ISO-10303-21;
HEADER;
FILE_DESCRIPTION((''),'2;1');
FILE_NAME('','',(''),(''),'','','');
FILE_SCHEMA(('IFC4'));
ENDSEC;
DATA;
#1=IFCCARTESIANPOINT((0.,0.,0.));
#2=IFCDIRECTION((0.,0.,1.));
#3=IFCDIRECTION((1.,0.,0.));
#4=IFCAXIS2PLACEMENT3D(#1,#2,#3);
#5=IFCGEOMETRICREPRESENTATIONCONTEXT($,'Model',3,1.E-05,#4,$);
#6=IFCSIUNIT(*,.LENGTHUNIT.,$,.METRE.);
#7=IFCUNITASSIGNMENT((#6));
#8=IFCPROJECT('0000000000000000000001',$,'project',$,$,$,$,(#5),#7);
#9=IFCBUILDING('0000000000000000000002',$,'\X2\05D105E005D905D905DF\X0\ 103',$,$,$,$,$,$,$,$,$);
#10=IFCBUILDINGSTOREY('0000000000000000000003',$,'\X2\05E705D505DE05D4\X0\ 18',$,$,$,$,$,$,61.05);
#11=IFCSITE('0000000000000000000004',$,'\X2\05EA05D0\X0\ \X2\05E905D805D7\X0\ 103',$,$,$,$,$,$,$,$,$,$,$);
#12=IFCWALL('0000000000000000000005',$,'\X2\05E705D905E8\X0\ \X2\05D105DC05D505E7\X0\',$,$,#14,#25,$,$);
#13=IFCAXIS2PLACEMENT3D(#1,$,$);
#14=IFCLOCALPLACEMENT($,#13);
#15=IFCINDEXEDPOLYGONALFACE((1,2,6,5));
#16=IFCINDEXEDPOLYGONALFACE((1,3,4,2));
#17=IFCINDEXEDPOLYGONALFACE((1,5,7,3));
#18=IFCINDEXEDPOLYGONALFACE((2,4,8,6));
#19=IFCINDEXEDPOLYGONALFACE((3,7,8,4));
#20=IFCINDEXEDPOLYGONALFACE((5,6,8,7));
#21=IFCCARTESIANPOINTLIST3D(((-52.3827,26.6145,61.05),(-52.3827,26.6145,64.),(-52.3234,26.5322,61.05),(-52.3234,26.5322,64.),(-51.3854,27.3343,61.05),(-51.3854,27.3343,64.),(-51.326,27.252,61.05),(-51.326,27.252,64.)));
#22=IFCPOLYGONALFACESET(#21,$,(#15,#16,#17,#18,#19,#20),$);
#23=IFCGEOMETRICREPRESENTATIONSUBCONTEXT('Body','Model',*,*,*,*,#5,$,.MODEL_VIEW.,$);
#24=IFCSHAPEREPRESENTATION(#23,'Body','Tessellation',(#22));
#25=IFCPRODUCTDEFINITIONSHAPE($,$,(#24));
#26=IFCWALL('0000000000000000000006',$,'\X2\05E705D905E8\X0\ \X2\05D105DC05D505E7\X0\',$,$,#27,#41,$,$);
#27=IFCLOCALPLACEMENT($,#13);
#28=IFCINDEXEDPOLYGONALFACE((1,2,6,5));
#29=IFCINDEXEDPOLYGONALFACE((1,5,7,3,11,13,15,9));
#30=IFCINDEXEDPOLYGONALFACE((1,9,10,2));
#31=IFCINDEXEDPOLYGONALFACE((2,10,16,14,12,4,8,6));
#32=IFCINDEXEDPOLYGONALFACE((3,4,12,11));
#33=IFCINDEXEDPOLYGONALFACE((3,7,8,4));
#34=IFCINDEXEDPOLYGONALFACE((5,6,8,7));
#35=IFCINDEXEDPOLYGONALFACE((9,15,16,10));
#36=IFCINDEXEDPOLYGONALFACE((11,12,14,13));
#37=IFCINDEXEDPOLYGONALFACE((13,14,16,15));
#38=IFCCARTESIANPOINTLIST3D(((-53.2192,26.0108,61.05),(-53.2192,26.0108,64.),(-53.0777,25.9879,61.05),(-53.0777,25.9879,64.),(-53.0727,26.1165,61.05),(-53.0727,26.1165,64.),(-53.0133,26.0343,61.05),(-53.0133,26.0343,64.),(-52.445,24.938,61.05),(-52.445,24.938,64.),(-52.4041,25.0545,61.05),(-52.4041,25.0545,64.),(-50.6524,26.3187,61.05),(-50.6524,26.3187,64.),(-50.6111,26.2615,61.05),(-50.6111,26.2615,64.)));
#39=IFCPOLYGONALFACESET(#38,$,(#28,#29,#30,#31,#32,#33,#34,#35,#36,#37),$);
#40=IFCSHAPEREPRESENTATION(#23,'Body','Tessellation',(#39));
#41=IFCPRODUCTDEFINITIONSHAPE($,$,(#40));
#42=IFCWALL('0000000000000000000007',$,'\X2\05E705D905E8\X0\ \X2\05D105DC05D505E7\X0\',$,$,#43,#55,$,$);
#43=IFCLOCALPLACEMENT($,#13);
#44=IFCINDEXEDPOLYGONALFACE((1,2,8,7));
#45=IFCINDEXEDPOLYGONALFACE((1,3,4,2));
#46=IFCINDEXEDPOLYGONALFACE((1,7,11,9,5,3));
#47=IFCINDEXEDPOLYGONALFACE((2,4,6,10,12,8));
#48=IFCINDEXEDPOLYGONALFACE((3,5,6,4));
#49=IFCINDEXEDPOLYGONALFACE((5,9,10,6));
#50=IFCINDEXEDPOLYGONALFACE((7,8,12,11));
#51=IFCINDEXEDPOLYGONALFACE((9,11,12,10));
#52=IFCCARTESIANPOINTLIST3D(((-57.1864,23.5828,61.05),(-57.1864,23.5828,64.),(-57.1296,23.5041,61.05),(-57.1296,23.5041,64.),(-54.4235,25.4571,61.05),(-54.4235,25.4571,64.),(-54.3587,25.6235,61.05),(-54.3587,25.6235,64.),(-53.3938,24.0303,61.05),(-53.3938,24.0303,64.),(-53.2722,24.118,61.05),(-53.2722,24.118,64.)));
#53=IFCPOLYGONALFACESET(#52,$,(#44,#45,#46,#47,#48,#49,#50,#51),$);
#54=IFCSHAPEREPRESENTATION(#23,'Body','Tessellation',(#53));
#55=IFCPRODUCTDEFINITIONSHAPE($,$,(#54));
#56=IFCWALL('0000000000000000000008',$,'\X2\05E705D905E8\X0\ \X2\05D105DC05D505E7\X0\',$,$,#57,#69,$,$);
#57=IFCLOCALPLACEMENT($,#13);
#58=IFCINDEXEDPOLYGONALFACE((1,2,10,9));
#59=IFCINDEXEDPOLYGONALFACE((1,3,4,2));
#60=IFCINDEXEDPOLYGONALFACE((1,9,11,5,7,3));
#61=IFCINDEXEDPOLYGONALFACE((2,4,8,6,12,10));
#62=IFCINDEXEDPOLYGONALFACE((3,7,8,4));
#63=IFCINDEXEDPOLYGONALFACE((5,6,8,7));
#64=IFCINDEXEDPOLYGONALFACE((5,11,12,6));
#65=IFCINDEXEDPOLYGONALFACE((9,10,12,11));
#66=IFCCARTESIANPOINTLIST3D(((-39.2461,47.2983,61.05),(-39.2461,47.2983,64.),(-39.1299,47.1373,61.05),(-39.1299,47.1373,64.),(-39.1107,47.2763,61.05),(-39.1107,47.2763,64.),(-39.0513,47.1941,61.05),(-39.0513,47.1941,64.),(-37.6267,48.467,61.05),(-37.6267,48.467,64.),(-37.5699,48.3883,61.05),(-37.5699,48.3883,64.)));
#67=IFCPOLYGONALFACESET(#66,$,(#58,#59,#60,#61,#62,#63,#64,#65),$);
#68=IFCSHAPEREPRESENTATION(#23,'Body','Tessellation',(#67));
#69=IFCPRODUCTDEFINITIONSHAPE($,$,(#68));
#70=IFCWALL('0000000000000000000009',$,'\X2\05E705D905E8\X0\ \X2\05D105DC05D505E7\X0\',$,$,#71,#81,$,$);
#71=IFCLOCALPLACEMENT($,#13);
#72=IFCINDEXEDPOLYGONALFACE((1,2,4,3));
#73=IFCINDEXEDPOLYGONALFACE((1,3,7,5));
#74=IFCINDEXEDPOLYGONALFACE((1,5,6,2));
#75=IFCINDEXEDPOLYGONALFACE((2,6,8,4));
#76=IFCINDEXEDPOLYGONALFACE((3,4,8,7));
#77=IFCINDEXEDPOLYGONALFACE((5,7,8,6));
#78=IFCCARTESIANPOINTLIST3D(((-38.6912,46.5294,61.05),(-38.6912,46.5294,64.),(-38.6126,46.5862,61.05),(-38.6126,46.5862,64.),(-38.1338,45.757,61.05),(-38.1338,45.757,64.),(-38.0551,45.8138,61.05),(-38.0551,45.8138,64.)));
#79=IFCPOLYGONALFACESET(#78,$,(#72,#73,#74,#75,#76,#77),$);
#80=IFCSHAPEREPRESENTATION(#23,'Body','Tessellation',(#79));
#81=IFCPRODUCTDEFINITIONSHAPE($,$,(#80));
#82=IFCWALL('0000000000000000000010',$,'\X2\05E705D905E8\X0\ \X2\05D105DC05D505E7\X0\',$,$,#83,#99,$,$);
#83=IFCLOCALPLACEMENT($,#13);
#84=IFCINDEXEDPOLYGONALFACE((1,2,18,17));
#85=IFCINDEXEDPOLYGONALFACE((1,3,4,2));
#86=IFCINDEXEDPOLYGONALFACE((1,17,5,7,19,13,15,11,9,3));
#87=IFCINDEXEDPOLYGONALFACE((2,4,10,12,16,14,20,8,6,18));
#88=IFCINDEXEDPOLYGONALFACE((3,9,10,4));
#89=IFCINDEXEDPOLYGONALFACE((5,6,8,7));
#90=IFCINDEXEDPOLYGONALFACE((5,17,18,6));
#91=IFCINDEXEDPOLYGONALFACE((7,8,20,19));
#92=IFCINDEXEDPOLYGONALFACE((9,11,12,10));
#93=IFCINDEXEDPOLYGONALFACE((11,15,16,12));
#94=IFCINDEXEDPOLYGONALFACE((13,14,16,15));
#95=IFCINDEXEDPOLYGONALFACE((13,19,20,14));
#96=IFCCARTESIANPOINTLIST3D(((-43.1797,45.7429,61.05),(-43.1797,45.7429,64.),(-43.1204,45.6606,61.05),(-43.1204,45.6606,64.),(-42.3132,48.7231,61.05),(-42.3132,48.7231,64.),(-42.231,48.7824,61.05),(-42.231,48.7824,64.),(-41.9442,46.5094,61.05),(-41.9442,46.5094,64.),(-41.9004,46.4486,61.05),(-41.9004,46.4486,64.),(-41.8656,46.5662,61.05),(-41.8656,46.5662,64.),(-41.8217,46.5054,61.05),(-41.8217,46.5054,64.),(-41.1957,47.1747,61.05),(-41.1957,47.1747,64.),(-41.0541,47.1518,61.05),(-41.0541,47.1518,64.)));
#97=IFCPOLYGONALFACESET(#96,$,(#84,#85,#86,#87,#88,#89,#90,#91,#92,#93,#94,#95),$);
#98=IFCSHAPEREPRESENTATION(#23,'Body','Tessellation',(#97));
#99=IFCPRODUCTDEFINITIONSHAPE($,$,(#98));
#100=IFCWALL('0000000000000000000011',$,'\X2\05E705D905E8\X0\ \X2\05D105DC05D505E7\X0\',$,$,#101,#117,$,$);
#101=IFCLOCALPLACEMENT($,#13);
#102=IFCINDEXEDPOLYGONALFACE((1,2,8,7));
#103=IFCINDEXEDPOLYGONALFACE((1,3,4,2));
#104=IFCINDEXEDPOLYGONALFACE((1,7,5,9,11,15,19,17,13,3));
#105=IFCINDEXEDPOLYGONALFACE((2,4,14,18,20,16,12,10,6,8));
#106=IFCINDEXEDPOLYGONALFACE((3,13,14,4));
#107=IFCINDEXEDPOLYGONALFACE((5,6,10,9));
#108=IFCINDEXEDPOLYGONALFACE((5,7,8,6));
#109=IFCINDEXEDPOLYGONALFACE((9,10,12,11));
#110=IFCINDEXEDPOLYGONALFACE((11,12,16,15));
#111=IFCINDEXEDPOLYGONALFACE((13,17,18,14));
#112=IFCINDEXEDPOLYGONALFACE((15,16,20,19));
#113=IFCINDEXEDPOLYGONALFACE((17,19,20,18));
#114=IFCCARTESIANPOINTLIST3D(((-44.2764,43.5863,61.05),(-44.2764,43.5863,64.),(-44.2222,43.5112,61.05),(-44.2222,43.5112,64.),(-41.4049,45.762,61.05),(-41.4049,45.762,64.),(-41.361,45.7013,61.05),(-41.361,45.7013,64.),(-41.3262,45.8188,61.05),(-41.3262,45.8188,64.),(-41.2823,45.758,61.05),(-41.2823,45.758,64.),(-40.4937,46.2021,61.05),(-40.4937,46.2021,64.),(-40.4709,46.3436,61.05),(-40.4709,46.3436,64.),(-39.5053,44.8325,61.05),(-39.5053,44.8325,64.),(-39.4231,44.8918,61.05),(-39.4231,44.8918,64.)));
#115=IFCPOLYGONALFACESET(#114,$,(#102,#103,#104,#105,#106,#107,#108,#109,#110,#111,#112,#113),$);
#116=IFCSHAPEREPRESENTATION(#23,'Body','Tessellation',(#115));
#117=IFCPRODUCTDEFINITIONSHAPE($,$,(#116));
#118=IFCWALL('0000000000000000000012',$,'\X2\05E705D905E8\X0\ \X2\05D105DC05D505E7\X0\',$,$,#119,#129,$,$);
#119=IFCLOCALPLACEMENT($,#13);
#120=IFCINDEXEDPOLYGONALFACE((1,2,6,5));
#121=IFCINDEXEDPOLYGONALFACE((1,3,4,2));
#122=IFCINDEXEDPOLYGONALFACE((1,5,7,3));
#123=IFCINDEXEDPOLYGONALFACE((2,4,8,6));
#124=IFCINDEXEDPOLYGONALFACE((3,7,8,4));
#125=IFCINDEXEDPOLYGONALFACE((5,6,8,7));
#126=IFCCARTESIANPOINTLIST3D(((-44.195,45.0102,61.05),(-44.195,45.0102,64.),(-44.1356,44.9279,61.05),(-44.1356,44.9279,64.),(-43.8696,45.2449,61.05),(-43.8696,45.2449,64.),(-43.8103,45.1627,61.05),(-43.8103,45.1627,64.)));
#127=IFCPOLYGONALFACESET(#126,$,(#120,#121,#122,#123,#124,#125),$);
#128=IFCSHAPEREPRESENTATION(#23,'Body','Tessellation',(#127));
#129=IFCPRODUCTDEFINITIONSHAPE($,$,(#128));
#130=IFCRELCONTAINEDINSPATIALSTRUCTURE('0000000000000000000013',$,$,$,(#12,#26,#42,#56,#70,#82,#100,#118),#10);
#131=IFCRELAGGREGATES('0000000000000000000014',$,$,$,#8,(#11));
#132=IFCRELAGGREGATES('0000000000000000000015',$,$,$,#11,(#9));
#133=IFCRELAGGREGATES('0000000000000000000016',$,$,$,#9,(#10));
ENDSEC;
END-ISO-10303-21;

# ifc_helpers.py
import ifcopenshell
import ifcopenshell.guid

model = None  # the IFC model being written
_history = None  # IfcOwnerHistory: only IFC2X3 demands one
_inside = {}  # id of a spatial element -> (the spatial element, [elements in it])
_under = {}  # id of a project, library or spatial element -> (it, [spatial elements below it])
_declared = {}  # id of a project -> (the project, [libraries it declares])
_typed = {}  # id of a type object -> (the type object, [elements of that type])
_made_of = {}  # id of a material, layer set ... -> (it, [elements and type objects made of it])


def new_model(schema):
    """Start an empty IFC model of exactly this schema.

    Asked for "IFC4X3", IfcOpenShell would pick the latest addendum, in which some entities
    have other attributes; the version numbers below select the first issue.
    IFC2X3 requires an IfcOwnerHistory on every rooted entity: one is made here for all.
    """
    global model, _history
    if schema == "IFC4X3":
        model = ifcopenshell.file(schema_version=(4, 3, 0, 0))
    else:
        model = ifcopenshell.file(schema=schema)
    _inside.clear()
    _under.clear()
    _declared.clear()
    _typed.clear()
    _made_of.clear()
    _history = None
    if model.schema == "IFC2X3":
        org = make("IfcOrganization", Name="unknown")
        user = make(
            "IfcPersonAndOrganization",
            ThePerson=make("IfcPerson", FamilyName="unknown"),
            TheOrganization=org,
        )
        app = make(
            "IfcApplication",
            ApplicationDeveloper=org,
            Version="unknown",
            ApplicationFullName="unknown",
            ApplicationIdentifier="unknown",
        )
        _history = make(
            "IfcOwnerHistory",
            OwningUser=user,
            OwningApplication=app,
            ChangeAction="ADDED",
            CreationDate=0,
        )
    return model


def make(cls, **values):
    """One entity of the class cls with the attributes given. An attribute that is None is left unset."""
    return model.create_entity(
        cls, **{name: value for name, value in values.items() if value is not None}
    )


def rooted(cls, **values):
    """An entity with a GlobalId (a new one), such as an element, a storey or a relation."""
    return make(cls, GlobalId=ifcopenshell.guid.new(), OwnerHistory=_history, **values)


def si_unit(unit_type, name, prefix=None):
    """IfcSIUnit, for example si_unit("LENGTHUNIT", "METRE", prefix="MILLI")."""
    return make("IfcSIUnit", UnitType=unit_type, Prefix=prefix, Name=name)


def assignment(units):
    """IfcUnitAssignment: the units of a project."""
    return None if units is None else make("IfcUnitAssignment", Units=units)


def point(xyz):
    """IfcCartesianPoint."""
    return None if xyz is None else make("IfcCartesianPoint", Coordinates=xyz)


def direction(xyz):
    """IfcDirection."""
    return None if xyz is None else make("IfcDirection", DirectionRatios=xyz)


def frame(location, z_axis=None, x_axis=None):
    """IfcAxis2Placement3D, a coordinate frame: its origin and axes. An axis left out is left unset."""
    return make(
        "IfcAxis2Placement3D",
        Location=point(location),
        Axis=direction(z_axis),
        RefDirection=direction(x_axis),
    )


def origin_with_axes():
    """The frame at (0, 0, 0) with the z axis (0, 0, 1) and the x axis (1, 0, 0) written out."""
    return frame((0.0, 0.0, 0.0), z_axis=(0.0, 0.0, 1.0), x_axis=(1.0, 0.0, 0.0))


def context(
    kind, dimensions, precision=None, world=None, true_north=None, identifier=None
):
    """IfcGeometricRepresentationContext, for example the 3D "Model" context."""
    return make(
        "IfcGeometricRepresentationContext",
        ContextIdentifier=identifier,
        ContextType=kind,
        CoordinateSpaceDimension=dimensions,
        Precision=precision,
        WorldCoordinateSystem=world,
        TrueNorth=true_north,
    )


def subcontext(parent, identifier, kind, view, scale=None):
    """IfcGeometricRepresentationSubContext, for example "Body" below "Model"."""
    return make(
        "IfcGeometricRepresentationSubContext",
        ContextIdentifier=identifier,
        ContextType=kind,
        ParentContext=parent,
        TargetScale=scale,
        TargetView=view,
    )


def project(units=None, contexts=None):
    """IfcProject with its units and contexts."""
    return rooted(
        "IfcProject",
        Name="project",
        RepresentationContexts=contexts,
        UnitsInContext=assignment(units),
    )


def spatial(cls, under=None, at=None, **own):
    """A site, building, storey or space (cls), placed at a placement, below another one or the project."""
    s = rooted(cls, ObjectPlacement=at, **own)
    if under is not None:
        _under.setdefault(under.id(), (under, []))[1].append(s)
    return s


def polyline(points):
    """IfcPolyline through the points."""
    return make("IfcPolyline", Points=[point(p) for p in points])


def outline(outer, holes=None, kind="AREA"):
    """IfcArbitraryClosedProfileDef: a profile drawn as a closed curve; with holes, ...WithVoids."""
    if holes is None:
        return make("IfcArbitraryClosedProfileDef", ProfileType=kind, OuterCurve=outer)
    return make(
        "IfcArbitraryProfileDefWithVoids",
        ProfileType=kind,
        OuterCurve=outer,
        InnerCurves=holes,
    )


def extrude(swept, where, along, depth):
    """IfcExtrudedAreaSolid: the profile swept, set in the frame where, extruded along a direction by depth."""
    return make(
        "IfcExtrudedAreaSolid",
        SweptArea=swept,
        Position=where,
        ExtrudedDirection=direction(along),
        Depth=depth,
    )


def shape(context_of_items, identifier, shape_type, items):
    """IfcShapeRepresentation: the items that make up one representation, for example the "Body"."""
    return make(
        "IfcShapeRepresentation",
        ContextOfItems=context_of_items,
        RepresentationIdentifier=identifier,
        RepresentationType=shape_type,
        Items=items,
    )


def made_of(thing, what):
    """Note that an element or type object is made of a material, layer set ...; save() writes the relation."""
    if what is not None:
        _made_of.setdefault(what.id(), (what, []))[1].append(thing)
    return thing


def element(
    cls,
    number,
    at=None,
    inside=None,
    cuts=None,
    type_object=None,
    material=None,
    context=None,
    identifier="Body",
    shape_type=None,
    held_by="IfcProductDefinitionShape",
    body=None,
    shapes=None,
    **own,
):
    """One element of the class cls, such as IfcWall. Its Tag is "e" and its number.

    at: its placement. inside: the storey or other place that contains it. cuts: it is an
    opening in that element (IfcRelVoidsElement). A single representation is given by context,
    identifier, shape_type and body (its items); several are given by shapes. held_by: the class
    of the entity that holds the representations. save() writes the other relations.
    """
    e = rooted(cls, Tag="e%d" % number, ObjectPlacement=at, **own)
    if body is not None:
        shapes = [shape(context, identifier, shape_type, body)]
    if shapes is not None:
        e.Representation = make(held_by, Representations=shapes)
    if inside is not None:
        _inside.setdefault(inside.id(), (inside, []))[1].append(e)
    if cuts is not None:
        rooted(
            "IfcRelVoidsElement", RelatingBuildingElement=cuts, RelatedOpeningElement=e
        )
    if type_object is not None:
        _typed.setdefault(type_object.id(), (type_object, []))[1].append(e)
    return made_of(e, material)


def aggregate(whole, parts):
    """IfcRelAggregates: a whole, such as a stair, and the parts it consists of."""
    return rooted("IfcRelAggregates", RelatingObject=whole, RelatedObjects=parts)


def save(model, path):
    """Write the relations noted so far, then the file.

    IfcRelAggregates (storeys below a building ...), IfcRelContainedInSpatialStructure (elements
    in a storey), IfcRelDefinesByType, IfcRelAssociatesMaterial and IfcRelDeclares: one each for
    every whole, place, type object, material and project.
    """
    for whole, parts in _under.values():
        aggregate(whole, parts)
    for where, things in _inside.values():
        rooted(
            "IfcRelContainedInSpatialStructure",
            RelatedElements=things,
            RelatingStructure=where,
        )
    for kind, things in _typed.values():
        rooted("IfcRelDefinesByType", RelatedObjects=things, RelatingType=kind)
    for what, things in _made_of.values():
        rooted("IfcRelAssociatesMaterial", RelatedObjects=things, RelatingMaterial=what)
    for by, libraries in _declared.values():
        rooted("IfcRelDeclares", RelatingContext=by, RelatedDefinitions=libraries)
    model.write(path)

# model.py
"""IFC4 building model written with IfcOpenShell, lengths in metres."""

from ifc_helpers import new_model, si_unit, frame, origin_with_axes, context, subcontext, project, spatial, polyline, outline, extrude, element, save


model = new_model("IFC4")

# Units and contexts
model_context = context("Model", 3, precision=1e-05, world=origin_with_axes())
body_context = subcontext(model_context, "Body", "Model", "MODEL_VIEW")
ifc_project = project(units=[si_unit("LENGTHUNIT", "METRE")], contexts=[model_context])

# Site, building, storey
site = spatial("IfcSite", under=ifc_project, Name="תא שטח 103")
building = spatial("IfcBuilding", under=site, Name="בניין 103")
storey = spatial("IfcBuildingStorey", under=building, Name="קומה 18", Elevation=61.05)

# Walls
element("IfcWall", 1, inside=storey, Name="קיר בלוק", context=body_context, shape_type="SweptSolid", body=[
    extrude(outline(polyline([(-52.3827, 26.6145), (-51.3854, 27.3343), (-51.326, 27.252), (-52.3234, 26.5322), (-52.3827, 26.6145)])), frame((0.0, 0.0, 61.05)), (0.0, 0.0, 1.0), 2.95),
])
element("IfcWall", 2, inside=storey, Name="קיר בלוק", context=body_context, shape_type="SweptSolid", body=[
    extrude(outline(polyline([(-53.2192, 26.0108), (-53.0727, 26.1165), (-53.0133, 26.0343), (-53.0777, 25.9879), (-52.4041, 25.0545), (-50.6524, 26.3187), (-50.6111, 26.2615), (-52.445, 24.938), (-53.2192, 26.0108)])), frame((0.0, 0.0, 61.05)), (0.0, 0.0, 1.0), 2.95),
])
element("IfcWall", 3, inside=storey, Name="קיר בלוק", context=body_context, shape_type="SweptSolid", body=[
    extrude(outline(polyline([(-53.3938, 24.0303), (-54.4235, 25.4571), (-57.1296, 23.5041), (-57.1864, 23.5828), (-54.3587, 25.6235), (-53.2722, 24.118), (-53.3938, 24.0303)])), frame((0.0, 0.0, 61.05)), (0.0, 0.0, 1.0), 2.95),
])
element("IfcWall", 4, inside=storey, Name="קיר בלוק", context=body_context, shape_type="SweptSolid", body=[
    extrude(outline(polyline([(-39.1299, 47.1373), (-39.2461, 47.2983), (-37.6267, 48.467), (-37.5699, 48.3883), (-39.1107, 47.2763), (-39.0513, 47.1941), (-39.1299, 47.1373)])), frame((0.0, 0.0, 61.05)), (0.0, 0.0, 1.0), 2.95),
])
element("IfcWall", 5, inside=storey, Name="קיר בלוק", context=body_context, shape_type="SweptSolid", body=[
    extrude(outline(polyline([(-38.6126, 46.5862), (-38.0551, 45.8138), (-38.1338, 45.757), (-38.6912, 46.5294), (-38.6126, 46.5862)])), frame((0.0, 0.0, 61.05)), (0.0, 0.0, 1.0), 2.95),
])
element("IfcWall", 6, inside=storey, Name="קיר בלוק", context=body_context, shape_type="SweptSolid", body=[
    extrude(outline(polyline([(-41.9004, 46.4486), (-41.9442, 46.5094), (-43.1204, 45.6606), (-43.1797, 45.7429), (-41.1957, 47.1747), (-42.3132, 48.7231), (-42.231, 48.7824), (-41.0541, 47.1518), (-41.8656, 46.5662), (-41.8217, 46.5054), (-41.9004, 46.4486)])), frame((0.0, 0.0, 61.05)), (0.0, 0.0, 1.0), 2.95),
])
element("IfcWall", 7, inside=storey, Name="קיר בלוק", context=body_context, shape_type="SweptSolid", body=[
    extrude(outline(polyline([(-44.2764, 43.5863), (-41.361, 45.7013), (-41.4049, 45.762), (-41.3262, 45.8188), (-41.2823, 45.758), (-40.4709, 46.3436), (-39.4231, 44.8918), (-39.5053, 44.8325), (-40.4937, 46.2021), (-44.2222, 43.5112), (-44.2764, 43.5863)])), frame((0.0, 0.0, 61.05)), (0.0, 0.0, 1.0), 2.95),
])
element("IfcWall", 8, inside=storey, Name="קיר בלוק", context=body_context, shape_type="SweptSolid", body=[
    extrude(outline(polyline([(-43.8103, 45.1627), (-44.1356, 44.9279), (-44.195, 45.0102), (-43.8696, 45.2449), (-43.8103, 45.1627)])), frame((0.0, 0.0, 61.05)), (0.0, 0.0, 1.0), 2.95),
])

save(model, "model.ifc")
